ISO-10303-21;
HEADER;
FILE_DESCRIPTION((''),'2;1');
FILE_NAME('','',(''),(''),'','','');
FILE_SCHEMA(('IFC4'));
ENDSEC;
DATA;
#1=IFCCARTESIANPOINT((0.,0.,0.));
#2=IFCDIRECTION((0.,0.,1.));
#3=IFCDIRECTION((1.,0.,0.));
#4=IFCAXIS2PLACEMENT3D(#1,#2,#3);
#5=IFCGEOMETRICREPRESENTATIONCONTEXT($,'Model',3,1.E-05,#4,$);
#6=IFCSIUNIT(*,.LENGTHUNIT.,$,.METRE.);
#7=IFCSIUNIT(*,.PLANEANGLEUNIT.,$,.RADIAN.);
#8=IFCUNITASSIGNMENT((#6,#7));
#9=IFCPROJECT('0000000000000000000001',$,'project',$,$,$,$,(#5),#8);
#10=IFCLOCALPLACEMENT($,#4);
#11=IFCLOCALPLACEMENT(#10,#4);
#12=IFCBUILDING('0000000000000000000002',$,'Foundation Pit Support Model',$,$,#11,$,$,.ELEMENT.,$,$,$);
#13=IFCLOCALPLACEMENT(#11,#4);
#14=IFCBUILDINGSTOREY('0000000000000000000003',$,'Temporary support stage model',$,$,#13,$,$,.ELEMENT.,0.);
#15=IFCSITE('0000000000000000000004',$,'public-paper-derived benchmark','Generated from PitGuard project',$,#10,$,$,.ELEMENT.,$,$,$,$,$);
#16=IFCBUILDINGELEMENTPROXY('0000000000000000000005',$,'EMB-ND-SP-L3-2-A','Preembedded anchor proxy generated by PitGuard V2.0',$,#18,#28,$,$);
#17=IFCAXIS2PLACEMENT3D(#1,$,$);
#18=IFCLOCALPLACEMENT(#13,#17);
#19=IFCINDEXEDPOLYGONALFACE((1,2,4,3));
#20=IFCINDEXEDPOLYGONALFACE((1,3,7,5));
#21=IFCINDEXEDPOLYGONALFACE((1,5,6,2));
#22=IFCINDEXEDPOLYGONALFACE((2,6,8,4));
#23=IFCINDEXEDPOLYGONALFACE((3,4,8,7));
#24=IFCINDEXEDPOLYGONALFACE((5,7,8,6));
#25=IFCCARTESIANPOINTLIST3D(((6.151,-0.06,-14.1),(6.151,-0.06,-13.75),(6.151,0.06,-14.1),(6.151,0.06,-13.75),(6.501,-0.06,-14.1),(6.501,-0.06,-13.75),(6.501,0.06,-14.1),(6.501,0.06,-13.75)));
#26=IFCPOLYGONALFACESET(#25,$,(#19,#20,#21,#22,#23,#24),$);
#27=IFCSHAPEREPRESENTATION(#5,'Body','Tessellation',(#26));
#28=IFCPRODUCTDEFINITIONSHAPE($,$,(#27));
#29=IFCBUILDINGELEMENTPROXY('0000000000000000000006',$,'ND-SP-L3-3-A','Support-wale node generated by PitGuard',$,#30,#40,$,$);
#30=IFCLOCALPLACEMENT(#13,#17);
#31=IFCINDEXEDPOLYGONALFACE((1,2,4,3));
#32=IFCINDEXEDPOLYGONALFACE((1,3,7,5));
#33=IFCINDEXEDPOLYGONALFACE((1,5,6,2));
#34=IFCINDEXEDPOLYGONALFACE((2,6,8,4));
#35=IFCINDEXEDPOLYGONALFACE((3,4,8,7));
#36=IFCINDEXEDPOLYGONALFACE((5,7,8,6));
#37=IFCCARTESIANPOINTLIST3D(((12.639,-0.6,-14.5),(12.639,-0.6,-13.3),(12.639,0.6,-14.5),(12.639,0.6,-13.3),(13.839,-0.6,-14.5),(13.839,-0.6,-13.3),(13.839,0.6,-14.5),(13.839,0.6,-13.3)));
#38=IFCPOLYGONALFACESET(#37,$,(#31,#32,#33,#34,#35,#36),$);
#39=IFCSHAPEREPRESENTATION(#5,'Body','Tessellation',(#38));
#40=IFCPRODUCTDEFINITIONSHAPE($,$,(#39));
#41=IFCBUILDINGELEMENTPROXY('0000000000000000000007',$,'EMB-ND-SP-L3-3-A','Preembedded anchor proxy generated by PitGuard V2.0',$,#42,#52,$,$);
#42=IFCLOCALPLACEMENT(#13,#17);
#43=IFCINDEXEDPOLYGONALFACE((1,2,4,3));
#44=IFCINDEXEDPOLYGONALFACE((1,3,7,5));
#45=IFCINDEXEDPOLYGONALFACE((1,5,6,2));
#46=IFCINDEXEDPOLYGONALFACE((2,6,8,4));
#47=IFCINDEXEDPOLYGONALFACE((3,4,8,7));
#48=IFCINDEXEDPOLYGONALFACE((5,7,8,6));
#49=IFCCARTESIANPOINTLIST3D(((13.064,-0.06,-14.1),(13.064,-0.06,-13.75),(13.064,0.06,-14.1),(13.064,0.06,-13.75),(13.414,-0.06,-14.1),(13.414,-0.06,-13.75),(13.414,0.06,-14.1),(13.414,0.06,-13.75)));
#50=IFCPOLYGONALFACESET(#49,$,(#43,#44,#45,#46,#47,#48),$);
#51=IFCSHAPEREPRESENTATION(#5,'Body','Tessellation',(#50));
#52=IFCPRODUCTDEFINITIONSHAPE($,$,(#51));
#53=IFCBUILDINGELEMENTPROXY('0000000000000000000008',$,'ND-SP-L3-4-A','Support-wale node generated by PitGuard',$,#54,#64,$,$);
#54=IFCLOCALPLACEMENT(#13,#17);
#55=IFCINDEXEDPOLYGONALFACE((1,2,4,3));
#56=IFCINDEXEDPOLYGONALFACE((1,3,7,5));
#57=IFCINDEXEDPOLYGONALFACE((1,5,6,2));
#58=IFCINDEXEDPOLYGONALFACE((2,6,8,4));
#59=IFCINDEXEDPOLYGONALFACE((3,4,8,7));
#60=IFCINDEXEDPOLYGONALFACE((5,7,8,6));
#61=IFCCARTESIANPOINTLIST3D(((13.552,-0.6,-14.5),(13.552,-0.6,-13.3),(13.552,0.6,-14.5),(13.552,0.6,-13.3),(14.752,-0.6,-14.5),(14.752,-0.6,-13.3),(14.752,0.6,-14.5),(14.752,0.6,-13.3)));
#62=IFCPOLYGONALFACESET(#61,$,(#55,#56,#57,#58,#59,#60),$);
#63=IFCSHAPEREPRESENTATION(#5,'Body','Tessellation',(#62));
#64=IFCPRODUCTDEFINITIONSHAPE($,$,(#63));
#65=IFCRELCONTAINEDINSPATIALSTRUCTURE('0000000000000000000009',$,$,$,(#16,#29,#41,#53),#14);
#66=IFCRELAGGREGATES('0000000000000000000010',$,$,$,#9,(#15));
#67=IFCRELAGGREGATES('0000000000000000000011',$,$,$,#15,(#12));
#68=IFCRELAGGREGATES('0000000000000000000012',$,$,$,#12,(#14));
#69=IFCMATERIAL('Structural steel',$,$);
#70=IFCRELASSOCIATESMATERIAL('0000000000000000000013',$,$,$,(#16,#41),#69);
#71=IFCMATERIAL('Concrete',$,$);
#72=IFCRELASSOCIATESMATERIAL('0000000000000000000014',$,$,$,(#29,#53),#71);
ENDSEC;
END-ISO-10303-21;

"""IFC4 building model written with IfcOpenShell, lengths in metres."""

from ifc_helpers import new_model, si_unit, frame, origin_with_axes, origin_2d, place, context, project, spatial, rectangle, extrude, material, element, save


model = new_model("IFC4")

# Units and contexts
model_context = context("Model", 3, precision=1e-05, world=origin_with_axes())
ifc_project = project(units=[si_unit("LENGTHUNIT", "METRE"), si_unit("PLANEANGLEUNIT", "RADIAN")], contexts=[model_context])

# Site, building, storey
site_placement = place(None, origin_with_axes())
site = spatial("IfcSite", under=ifc_project, at=site_placement, Name="public-paper-derived benchmark", Description="Generated from PitGuard project", CompositionType="ELEMENT")
building_placement = place(site_placement, origin_with_axes())
building = spatial("IfcBuilding", under=site, at=building_placement, Name="Foundation Pit Support Model", CompositionType="ELEMENT")
storey_placement = place(building_placement, origin_with_axes())
storey = spatial("IfcBuildingStorey", under=building, at=storey_placement, Name="Temporary support stage model", CompositionType="ELEMENT", Elevation=0.0)

# Shared definitions
ifc_material_1 = material(Name="Structural steel")

# Shared definitions
ifc_material_2 = material(Name="Concrete")

# Building element proxies
proxy_1_placement = place(storey_placement, frame((6.326, 0.0, -14.1), z_axis=(0.0, 0.0, 1.0), x_axis=(1.0, 0.0, 0.0)))
element("IfcBuildingElementProxy", 1, at=proxy_1_placement, inside=storey, material=ifc_material_1, Name="EMB-ND-SP-L3-2-A", Description="Preembedded anchor proxy generated by PitGuard V2.0", context=model_context, shape_type="SweptSolid", body=[
    extrude(rectangle(XDim=0.35, YDim=0.12, at=origin_2d()), origin_with_axes(), (0.0, 0.0, 1.0), 0.35),
])
proxy_2_placement = place(storey_placement, frame((13.239, 0.0, -14.5), z_axis=(0.0, 0.0, 1.0), x_axis=(1.0, 0.0, 0.0)))
element("IfcBuildingElementProxy", 2, at=proxy_2_placement, inside=storey, material=ifc_material_2, Name="ND-SP-L3-3-A", Description="Support-wale node generated by PitGuard", context=model_context, shape_type="SweptSolid", body=[
    extrude(rectangle(XDim=1.2, YDim=1.2, at=origin_2d()), origin_with_axes(), (0.0, 0.0, 1.0), 1.2),
])
proxy_3_placement = place(storey_placement, frame((13.239, 0.0, -14.1), z_axis=(0.0, 0.0, 1.0), x_axis=(1.0, 0.0, 0.0)))
element("IfcBuildingElementProxy", 3, at=proxy_3_placement, inside=storey, material=ifc_material_1, Name="EMB-ND-SP-L3-3-A", Description="Preembedded anchor proxy generated by PitGuard V2.0", context=model_context, shape_type="SweptSolid", body=[
    extrude(rectangle(XDim=0.35, YDim=0.12, at=origin_2d()), origin_with_axes(), (0.0, 0.0, 1.0), 0.35),
])
proxy_4_placement = place(storey_placement, frame((14.152, 0.0, -14.5), z_axis=(0.0, 0.0, 1.0), x_axis=(1.0, 0.0, 0.0)))
element("IfcBuildingElementProxy", 4, at=proxy_4_placement, inside=storey, material=ifc_material_2, Name="ND-SP-L3-4-A", Description="Support-wale node generated by PitGuard", context=model_context, shape_type="SweptSolid", body=[
    extrude(rectangle(XDim=1.2, YDim=1.2, at=origin_2d()), origin_with_axes(), (0.0, 0.0, 1.0), 1.2),
])

save(model, "model.ifc")
